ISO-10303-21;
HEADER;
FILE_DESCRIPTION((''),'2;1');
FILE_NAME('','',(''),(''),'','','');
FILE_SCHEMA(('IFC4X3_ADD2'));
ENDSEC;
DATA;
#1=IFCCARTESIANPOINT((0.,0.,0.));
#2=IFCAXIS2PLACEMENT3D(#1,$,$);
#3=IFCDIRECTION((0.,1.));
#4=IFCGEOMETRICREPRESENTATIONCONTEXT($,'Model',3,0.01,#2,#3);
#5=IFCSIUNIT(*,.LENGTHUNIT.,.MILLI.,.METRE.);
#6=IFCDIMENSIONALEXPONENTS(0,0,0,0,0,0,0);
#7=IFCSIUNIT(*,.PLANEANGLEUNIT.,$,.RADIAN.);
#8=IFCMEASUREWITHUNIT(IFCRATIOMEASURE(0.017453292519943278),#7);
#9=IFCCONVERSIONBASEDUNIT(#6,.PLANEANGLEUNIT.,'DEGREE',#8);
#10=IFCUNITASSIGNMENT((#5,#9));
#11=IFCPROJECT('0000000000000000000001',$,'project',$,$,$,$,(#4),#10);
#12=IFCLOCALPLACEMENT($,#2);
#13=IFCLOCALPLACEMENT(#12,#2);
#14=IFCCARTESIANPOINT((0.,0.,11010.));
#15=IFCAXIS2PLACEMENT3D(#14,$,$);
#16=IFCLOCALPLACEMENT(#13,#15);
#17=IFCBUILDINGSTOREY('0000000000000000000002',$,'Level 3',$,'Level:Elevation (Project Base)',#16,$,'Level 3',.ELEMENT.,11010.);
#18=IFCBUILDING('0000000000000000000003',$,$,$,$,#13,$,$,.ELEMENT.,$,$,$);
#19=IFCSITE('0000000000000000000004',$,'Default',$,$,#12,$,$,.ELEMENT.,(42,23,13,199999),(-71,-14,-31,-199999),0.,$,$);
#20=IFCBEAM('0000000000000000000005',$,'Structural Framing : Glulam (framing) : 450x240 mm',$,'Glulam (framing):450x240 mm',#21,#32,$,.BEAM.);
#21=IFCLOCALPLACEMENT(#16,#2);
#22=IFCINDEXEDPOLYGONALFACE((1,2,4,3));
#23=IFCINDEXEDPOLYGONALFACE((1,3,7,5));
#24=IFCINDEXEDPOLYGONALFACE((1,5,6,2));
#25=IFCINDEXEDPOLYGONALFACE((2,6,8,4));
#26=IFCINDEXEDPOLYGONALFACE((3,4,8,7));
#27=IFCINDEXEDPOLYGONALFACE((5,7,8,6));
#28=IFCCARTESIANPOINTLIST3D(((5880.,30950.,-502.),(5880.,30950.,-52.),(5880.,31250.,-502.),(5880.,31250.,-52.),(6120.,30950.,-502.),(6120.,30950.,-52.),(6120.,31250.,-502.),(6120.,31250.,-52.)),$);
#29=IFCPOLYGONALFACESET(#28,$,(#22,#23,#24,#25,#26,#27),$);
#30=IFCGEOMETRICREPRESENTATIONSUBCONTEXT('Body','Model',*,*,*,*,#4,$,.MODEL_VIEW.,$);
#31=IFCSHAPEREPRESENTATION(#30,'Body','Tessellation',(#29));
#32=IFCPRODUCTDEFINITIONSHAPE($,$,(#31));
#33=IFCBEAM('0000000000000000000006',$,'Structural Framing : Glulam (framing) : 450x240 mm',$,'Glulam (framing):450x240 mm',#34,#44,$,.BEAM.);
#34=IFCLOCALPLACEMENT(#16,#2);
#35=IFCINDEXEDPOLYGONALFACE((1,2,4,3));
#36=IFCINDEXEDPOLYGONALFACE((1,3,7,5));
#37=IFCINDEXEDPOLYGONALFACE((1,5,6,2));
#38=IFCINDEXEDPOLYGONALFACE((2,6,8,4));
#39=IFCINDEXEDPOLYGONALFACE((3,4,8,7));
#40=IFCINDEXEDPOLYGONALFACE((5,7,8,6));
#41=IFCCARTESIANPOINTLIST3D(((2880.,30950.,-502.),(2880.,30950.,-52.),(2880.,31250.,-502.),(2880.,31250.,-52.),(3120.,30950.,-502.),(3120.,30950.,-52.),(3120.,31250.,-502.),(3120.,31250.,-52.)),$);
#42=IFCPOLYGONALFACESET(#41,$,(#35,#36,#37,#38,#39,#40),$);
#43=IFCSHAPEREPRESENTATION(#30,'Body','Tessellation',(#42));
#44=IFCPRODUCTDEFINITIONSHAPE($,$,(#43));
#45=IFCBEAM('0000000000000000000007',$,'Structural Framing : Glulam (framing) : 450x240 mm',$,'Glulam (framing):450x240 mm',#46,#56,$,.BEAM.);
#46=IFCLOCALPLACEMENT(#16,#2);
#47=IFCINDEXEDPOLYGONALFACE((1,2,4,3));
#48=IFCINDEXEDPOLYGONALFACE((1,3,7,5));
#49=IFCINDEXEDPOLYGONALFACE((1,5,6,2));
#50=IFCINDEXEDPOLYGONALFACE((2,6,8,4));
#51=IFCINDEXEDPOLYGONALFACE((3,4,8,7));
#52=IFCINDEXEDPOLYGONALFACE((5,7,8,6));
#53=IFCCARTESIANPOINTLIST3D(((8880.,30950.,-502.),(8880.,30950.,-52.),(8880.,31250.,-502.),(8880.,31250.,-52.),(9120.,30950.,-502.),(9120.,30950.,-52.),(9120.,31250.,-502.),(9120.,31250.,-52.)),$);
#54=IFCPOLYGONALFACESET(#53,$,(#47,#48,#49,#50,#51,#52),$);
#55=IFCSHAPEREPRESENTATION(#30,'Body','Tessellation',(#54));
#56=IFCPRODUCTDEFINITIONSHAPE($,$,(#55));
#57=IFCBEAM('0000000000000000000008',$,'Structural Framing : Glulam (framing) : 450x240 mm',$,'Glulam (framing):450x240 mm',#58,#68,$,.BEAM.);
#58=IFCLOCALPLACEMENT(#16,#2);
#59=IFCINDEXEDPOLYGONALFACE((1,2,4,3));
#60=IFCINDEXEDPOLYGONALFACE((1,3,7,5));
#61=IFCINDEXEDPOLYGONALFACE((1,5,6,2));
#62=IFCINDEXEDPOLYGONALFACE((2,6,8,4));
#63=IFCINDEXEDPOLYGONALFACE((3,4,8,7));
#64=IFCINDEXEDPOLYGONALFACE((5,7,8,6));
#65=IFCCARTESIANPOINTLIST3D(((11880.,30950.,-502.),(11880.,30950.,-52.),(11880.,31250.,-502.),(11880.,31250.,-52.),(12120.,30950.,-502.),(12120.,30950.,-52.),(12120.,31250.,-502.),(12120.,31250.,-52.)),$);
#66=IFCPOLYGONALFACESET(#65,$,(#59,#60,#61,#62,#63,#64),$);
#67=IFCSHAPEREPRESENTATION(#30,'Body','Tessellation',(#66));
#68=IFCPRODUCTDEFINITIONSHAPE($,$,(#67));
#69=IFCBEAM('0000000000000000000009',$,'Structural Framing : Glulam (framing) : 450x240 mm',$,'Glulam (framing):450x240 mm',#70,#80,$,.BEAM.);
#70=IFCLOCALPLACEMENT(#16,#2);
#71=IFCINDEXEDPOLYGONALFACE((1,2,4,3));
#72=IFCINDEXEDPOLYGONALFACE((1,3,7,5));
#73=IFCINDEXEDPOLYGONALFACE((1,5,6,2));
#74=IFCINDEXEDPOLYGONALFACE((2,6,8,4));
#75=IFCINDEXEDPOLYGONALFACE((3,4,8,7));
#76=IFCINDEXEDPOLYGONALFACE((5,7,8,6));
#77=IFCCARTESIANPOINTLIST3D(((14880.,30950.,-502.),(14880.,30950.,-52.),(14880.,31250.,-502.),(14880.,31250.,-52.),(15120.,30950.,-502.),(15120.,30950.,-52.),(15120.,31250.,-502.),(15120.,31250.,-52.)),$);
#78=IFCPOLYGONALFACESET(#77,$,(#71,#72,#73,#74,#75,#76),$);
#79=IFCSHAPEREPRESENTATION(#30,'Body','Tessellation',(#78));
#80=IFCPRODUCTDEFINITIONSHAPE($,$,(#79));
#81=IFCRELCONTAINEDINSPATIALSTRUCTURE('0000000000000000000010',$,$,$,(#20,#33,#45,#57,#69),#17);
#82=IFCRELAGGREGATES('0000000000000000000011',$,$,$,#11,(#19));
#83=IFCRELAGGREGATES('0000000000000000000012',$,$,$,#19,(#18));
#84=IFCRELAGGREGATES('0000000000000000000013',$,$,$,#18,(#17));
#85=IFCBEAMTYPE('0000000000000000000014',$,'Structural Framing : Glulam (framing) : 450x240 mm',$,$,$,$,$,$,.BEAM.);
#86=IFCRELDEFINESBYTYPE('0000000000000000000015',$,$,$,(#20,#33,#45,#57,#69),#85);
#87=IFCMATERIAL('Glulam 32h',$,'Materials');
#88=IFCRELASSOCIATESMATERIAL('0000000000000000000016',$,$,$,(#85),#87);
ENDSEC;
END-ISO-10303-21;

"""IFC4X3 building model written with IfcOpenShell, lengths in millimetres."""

from ifc_helpers import new_model, entity, si_unit, converted_unit, direction, frame, origin, origin_2d_with_axis, place, context, subcontext, project, spatial, rectangle, extrude, source, transform, mapped, material, material_profile, profile_set, type_object, type_shapes, element, save


model = new_model("IFC4X3")

# Units and contexts
model_context = context("Model", 3, precision=0.01, world=origin(), true_north=direction((0.0, 1.0)))
body_context = subcontext(model_context, "Body", "Model", "MODEL_VIEW")
ifc_project = project(units=[si_unit("LENGTHUNIT", "METRE", prefix="MILLI"), converted_unit("PLANEANGLEUNIT", "DEGREE", entity("IfcRatioMeasure", 0.017453292519943278), si_unit("PLANEANGLEUNIT", "RADIAN"), dimensions=[0, 0, 0, 0, 0, 0, 0])], contexts=[model_context])

# Site, building, storey
site_placement = place(None, origin())
site = spatial("IfcSite", under=ifc_project, at=site_placement, Name="Default", CompositionType="ELEMENT", RefLatitude=(42, 23, 13, 199999), RefLongitude=(-71, -14, -31, -199999), RefElevation=0.0)
building_placement = place(site_placement, origin())
building = spatial("IfcBuilding", under=site, at=building_placement, CompositionType="ELEMENT")
storey_placement = place(building_placement, frame((0.0, 0.0, 11010.0)))
storey = spatial("IfcBuildingStorey", under=building, at=storey_placement, Name="Level 3", ObjectType="Level:Elevation (Project Base)", LongName="Level 3", CompositionType="ELEMENT", Elevation=11010.0)

# Beams
ifc_material_1 = material(Name="Glulam 32h", Category="Materials")
ifc_material_profile_1 = material_profile(ifc_material_1, rectangle(XDim=450.0, YDim=240.0, at=origin_2d_with_axis()), Name="450x240 mm")
ifc_profile_set_1 = profile_set([ifc_material_profile_1], Name="450x240 mm")
beam_type_1 = type_object("IfcBeamType", Name="Structural Framing : Glulam (framing) : 450x240 mm", PredefinedType="BEAM", material=ifc_profile_set_1)
shared_shape_1 = source(origin(), body_context, "Body", "SweptSolid", [
    extrude(rectangle(XDim=450.0, YDim=240.0, at=origin_2d_with_axis()), frame((4243.7, 0.0, 0.0), z_axis=(1.0, 0.0, 0.0), x_axis=(0.0, 0.0, -1.0)), (0.0, 0.0, 1.0), 300.0),
])
type_shapes(beam_type_1, [shared_shape_1])
for number, where, z_axis, x_axis, name in (
    (1, (6000.0, 35493.7, -277.0), (0.0, 0.0, 1.0), (0.0, -1.0, 0.0), "Structural Framing : Glulam (framing) : 450x240 mm"),
    (2, (3000.0, 35493.7, -277.0), (0.0, 0.0, 1.0), (0.0, -1.0, 0.0), "Structural Framing : Glulam (framing) : 450x240 mm"),
    (3, (9000.0, 35493.7, -277.0), (0.0, 0.0, 1.0), (0.0, -1.0, 0.0), "Structural Framing : Glulam (framing) : 450x240 mm"),
    (4, (12000.0, 35493.7, -277.0), (0.0, 0.0, 1.0), (0.0, -1.0, 0.0), "Structural Framing : Glulam (framing) : 450x240 mm"),
    (5, (15000.0, 35493.7, -277.0), (0.0, 0.0, 1.0), (0.0, -1.0, 0.0), "Structural Framing : Glulam (framing) : 450x240 mm"),
):
    element("IfcBeam", number, at=place(storey_placement, frame(where, z_axis=z_axis, x_axis=x_axis)), inside=storey, type_object=beam_type_1, Name=name, ObjectType="Glulam (framing):450x240 mm", PredefinedType="BEAM", context=body_context, shape_type="MappedRepresentation", body=[
        mapped(shared_shape_1, transform((0.0, 0.0, 0.0), scale=1.0)),
    ])

save(model, "model.ifc")
